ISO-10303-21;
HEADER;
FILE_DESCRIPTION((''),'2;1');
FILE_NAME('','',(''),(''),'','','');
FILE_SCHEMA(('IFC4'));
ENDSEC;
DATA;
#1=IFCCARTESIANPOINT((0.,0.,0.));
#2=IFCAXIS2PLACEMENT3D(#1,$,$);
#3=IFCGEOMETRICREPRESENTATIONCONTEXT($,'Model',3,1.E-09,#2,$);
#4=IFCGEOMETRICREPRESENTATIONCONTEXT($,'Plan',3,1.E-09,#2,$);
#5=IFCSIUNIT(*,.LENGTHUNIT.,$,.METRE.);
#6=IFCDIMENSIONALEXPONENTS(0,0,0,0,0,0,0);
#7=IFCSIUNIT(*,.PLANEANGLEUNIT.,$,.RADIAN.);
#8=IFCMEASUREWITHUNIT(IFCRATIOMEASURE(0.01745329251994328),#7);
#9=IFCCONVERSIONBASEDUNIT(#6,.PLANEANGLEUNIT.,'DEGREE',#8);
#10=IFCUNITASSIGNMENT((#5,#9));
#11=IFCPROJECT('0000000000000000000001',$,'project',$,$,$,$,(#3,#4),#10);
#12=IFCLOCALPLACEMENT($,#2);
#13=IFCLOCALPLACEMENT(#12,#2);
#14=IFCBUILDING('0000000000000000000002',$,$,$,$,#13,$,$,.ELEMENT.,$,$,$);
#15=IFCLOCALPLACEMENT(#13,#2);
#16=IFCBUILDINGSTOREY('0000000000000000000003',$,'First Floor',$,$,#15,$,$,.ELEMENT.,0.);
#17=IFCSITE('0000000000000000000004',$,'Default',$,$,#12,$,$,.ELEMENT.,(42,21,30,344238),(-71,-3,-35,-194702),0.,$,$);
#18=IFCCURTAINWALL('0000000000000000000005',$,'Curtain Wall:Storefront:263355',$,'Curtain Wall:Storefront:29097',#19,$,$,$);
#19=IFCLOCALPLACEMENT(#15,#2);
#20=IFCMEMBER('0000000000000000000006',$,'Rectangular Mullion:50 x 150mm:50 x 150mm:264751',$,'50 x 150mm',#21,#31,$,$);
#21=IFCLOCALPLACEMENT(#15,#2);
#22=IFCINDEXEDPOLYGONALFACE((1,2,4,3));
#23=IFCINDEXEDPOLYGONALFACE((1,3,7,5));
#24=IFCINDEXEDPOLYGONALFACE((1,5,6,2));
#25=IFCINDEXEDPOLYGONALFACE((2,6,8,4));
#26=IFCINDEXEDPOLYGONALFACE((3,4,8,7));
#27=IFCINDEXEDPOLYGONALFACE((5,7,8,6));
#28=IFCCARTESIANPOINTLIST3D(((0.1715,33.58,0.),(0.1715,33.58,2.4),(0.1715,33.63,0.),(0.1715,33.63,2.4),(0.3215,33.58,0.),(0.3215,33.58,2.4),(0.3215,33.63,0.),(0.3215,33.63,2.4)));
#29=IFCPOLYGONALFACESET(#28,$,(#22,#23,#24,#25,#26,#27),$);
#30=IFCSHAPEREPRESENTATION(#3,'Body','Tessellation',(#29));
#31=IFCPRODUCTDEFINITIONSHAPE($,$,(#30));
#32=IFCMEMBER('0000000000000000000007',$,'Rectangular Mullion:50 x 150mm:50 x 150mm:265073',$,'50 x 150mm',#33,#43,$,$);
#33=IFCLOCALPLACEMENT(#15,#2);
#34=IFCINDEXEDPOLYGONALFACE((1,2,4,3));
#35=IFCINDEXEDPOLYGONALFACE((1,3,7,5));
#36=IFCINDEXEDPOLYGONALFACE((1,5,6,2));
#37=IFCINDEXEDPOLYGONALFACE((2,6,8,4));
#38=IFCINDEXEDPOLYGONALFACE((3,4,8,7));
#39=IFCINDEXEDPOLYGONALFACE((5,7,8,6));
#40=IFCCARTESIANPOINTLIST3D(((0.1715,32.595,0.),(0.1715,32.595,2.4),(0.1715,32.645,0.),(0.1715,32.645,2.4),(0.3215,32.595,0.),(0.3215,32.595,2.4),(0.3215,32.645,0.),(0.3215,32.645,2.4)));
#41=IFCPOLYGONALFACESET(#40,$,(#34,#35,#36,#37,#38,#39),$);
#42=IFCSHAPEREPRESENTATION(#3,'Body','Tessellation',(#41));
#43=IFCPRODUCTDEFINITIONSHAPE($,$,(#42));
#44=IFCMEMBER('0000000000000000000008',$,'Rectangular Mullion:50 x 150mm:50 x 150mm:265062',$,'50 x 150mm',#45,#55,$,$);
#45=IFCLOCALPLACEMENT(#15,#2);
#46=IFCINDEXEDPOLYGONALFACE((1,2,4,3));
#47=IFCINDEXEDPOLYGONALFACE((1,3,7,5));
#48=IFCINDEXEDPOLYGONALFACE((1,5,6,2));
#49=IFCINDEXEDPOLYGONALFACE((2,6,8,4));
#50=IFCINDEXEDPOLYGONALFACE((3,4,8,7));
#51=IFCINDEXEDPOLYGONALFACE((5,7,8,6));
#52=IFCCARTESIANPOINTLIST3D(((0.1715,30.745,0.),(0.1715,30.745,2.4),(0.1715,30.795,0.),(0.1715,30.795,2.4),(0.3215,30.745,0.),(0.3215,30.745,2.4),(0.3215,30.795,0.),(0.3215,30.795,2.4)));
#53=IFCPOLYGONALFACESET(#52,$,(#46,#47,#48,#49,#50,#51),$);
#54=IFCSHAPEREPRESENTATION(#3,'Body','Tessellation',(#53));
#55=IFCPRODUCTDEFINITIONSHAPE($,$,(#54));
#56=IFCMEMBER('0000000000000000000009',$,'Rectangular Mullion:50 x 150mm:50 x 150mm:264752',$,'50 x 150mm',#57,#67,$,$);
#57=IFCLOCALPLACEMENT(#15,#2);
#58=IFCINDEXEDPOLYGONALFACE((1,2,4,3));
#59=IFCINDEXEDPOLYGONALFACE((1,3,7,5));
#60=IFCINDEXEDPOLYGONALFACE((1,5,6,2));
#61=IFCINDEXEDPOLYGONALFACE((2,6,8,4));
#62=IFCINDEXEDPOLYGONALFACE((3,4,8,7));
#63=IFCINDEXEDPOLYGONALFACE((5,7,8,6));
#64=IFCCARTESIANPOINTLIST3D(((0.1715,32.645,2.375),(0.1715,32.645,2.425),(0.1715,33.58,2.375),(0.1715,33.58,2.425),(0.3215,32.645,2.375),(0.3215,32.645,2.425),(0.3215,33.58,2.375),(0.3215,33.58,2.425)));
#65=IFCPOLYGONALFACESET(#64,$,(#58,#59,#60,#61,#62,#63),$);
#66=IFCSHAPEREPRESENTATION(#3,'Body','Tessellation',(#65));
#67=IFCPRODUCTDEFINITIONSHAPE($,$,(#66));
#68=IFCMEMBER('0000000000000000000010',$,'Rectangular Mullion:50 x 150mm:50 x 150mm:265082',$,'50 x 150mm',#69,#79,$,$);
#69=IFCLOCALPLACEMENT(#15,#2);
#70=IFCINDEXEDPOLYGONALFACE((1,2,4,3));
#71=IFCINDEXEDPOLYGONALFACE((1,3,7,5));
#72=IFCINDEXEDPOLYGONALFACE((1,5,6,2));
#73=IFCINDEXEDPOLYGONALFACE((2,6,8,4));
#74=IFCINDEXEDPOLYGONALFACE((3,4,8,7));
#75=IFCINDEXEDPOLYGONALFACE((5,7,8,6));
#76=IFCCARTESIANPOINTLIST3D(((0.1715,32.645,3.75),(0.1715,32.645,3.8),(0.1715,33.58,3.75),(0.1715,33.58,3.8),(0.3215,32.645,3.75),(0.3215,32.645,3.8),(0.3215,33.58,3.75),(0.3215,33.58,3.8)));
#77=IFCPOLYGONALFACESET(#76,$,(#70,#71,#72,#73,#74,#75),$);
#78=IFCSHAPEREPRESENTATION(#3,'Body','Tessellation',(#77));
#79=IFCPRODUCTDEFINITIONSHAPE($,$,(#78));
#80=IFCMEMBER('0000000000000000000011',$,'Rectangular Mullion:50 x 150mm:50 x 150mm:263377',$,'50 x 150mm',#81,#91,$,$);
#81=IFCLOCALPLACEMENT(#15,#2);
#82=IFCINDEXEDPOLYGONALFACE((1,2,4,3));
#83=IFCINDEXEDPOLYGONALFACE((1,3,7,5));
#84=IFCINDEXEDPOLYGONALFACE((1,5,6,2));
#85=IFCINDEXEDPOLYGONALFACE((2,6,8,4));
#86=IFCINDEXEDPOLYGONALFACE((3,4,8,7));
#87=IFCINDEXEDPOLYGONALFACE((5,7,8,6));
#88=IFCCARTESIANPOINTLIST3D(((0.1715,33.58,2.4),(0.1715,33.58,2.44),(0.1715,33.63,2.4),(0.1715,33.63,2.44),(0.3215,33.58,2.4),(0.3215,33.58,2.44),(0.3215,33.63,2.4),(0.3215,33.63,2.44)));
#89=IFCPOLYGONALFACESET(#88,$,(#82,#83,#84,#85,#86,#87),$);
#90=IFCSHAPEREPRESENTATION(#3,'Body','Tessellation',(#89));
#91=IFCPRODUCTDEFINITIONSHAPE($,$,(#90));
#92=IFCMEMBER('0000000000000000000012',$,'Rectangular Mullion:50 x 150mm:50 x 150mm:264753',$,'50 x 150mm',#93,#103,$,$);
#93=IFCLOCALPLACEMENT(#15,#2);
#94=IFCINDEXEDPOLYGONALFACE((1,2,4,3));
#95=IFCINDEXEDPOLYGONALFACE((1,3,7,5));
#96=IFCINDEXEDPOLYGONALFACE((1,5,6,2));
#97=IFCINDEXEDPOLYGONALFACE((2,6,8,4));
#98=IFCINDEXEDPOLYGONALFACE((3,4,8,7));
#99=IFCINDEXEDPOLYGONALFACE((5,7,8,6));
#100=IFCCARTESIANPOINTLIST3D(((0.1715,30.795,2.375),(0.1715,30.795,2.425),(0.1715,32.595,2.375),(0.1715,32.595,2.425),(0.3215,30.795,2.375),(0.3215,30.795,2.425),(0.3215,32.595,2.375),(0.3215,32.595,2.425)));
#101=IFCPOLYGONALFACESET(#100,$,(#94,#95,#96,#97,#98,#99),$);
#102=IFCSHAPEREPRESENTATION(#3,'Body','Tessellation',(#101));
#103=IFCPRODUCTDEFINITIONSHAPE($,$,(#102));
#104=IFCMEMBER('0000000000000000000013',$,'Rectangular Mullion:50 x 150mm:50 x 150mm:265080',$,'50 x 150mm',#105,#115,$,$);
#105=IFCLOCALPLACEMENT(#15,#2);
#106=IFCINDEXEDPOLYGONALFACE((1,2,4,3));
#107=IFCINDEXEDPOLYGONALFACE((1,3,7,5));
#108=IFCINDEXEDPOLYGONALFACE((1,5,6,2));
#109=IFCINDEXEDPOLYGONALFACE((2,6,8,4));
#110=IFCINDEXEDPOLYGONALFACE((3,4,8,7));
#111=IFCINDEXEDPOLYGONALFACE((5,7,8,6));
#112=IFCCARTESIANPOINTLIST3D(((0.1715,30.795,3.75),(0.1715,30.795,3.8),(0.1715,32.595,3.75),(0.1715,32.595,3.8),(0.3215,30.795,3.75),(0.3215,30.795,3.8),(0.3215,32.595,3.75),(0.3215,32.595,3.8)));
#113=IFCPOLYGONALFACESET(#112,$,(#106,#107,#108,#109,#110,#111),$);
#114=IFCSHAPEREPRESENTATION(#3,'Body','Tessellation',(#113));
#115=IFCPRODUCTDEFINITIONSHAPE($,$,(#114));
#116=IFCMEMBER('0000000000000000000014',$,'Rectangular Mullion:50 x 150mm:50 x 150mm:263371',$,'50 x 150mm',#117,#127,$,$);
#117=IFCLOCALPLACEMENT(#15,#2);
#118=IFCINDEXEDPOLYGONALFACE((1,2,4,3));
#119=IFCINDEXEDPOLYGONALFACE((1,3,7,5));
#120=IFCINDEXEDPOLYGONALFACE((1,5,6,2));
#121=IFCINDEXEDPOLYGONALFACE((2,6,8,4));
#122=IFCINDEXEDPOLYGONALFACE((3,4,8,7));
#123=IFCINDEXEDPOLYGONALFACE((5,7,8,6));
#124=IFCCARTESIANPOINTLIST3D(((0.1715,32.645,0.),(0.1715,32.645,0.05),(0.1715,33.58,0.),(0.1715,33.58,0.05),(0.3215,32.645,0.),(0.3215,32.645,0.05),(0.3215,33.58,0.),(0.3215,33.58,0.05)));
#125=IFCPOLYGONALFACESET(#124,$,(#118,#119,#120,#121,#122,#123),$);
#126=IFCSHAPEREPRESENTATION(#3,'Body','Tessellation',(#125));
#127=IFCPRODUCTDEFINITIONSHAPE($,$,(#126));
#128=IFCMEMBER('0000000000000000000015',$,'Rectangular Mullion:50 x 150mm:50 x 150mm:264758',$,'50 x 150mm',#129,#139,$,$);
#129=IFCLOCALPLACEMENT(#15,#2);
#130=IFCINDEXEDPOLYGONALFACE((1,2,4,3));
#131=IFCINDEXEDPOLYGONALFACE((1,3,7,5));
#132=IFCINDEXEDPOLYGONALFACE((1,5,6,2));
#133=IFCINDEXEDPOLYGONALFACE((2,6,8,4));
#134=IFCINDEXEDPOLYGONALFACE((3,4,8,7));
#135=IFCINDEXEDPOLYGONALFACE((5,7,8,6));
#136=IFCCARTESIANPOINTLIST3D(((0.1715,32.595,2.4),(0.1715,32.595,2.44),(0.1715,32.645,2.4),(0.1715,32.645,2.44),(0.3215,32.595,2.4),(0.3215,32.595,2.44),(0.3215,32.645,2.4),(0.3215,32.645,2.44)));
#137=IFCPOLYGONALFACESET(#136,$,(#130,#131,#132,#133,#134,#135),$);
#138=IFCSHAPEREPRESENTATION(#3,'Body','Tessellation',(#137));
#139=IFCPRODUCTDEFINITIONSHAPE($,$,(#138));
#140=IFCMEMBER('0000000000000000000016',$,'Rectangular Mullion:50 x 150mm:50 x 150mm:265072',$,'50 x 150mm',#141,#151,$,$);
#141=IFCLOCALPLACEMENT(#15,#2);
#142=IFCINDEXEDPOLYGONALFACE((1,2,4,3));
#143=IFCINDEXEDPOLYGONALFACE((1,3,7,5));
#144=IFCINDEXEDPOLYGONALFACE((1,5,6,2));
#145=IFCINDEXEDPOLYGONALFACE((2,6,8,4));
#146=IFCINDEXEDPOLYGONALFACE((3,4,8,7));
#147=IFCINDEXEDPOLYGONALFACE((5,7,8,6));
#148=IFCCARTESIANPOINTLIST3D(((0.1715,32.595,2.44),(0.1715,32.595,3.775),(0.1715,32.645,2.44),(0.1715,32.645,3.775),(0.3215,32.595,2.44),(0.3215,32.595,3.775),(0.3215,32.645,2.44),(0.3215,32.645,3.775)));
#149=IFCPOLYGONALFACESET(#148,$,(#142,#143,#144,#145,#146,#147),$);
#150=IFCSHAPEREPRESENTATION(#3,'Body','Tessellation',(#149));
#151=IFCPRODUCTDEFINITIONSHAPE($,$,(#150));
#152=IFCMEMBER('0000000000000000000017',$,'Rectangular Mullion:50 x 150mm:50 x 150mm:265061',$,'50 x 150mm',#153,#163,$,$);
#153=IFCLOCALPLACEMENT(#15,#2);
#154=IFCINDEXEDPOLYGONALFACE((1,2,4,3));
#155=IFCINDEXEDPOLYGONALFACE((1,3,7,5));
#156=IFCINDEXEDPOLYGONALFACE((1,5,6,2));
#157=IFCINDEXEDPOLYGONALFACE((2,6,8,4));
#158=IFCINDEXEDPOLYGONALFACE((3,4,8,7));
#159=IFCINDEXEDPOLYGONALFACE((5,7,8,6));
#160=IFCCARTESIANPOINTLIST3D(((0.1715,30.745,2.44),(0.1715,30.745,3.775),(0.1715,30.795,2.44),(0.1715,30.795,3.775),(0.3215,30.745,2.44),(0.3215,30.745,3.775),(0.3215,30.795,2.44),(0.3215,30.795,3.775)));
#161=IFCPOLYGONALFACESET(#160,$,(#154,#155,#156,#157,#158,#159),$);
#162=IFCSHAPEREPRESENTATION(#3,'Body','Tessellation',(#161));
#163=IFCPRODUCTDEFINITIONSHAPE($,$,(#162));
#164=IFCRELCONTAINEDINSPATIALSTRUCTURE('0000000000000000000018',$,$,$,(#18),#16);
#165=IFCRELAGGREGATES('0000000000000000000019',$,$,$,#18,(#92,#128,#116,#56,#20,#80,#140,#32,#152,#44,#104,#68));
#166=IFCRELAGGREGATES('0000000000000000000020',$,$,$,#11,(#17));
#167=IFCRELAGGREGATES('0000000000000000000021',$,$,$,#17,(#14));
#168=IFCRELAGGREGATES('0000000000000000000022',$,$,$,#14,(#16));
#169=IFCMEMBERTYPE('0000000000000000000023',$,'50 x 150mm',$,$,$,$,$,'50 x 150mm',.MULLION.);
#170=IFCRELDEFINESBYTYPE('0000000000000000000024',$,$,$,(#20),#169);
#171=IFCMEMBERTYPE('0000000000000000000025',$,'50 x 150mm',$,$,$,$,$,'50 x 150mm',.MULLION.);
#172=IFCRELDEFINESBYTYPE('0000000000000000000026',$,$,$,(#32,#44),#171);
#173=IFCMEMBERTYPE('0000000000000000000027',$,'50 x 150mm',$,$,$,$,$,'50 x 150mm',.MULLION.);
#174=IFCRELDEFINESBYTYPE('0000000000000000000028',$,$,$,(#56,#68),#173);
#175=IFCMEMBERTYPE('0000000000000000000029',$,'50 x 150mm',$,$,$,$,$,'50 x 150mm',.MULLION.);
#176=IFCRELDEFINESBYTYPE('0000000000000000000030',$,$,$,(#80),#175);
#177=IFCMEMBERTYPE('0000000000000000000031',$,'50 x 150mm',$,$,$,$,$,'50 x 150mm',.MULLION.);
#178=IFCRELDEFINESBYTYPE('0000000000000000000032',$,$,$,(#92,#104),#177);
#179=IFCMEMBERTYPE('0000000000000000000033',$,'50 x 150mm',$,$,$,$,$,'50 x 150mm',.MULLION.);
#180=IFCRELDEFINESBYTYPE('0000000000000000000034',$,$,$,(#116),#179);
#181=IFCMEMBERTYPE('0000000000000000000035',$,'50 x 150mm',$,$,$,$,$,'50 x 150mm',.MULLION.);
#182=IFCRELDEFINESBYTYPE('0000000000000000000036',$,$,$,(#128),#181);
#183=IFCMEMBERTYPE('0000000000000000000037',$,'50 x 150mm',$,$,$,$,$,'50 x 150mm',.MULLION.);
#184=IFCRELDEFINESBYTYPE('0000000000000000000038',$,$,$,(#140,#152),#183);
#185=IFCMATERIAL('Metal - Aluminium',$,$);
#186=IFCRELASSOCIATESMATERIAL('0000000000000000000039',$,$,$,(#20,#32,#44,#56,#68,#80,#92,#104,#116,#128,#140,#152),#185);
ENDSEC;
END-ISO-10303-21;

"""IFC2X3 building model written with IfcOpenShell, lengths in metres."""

from ifc_helpers import new_model, entity, si_unit, converted_unit, frame, origin, origin_2d_with_axis, place, context, project, spatial, rectangle, extrude, source, transform, mapped, material, type_object, type_shapes, element, aggregate, save


model = new_model("IFC2X3")

# Units and contexts
model_context = context("Model", 3, precision=1e-09, world=origin())
plan_context = context("Plan", 3, precision=1e-09, world=origin())
ifc_project = project(units=[si_unit("LENGTHUNIT", "METRE"), converted_unit("PLANEANGLEUNIT", "DEGREE", entity("IfcRatioMeasure", 0.01745329251994328), si_unit("PLANEANGLEUNIT", "RADIAN"), dimensions=[0, 0, 0, 0, 0, 0, 0])], contexts=[model_context, plan_context])

# Site, building, storey
site_placement = place(None, origin())
site = spatial("IfcSite", under=ifc_project, at=site_placement, Name="Default", CompositionType="ELEMENT", RefLatitude=(42, 21, 30, 344238), RefLongitude=(-71, -3, -35, -194702), RefElevation=0.0)
building_placement = place(site_placement, origin())
building = spatial("IfcBuilding", under=site, at=building_placement, CompositionType="ELEMENT")
storey_placement = place(building_placement, origin())
storey = spatial("IfcBuildingStorey", under=building, at=storey_placement, Name="First Floor", CompositionType="ELEMENT", Elevation=0.0)

# Curtain wall, members
curtain_wall_placement = place(storey_placement, origin())
curtain_wall = element("IfcCurtainWall", 1, at=curtain_wall_placement, inside=storey, Name="Curtain Wall:Storefront:263355", ObjectType="Curtain Wall:Storefront:29097")
ifc_material_1 = material(Name="Metal - Aluminium")
member_type_1 = type_object("IfcMemberType", Name="50 x 150mm", ElementType="50 x 150mm", PredefinedType="MULLION")
shared_shape_1 = source(origin(), model_context, "Body", "SweptSolid", [
    extrude(rectangle(XDim=0.05, YDim=0.15, at=origin_2d_with_axis()), frame((-0.025, 0.0, -2.4), z_axis=(0.0, 0.0, 1.0), x_axis=(-1.0, 0.0, 0.0)), (0.0, 0.0, 1.0), 2.4),
])
type_shapes(member_type_1, [shared_shape_1])
member_1_placement = place(storey_placement, frame((0.2465, 33.63, 2.4), z_axis=(0.0, 0.0, 1.0), x_axis=(0.0, 1.0, 0.0)))
member_1 = element("IfcMember", 2, at=member_1_placement, type_object=member_type_1, material=ifc_material_1, Name="Rectangular Mullion:50 x 150mm:50 x 150mm:264751", ObjectType="50 x 150mm", context=model_context, shape_type="MappedRepresentation", body=[
    mapped(shared_shape_1, transform((0.0, 0.0, 0.0), scale=1.0)),
])
member_type_2 = type_object("IfcMemberType", Name="50 x 150mm", ElementType="50 x 150mm", PredefinedType="MULLION")
shared_shape_2 = source(origin(), model_context, "Body", "SweptSolid", [
    extrude(rectangle(XDim=0.05, YDim=0.15, at=origin_2d_with_axis()), frame((0.0, 0.0, -2.4), z_axis=(0.0, 0.0, 1.0), x_axis=(-1.0, 0.0, 0.0)), (0.0, 0.0, 1.0), 2.4),
])
type_shapes(member_type_2, [shared_shape_2])
member_2_placement = place(storey_placement, frame((0.2465, 32.62, 0.0), z_axis=(0.0, 0.0, -1.0), x_axis=(0.0, -1.0, 0.0)))
member_2 = element("IfcMember", 3, at=member_2_placement, type_object=member_type_2, material=ifc_material_1, Name="Rectangular Mullion:50 x 150mm:50 x 150mm:265073", ObjectType="50 x 150mm", context=model_context, shape_type="MappedRepresentation", body=[
    mapped(shared_shape_2, transform((0.0, 0.0, 0.0), scale=1.0)),
])
member_3_placement = place(storey_placement, frame((0.2465, 30.77, 0.0), z_axis=(0.0, 0.0, -1.0), x_axis=(0.0, -1.0, 0.0)))
member_3 = element("IfcMember", 4, at=member_3_placement, type_object=member_type_2, material=ifc_material_1, Name="Rectangular Mullion:50 x 150mm:50 x 150mm:265062", ObjectType="50 x 150mm", context=model_context, shape_type="MappedRepresentation", body=[
    mapped(shared_shape_2, transform((0.0, 0.0, 0.0), scale=1.0)),
])
member_type_3 = type_object("IfcMemberType", Name="50 x 150mm", ElementType="50 x 150mm", PredefinedType="MULLION")
shared_shape_3 = source(origin(), model_context, "Body", "SweptSolid", [
    extrude(rectangle(XDim=0.05, YDim=0.15, at=origin_2d_with_axis()), frame((0.0, 0.0, -0.935), z_axis=(0.0, 0.0, 1.0), x_axis=(-1.0, 0.0, 0.0)), (0.0, 0.0, 1.0), 0.935),
])
type_shapes(member_type_3, [shared_shape_3])
member_4_placement = place(storey_placement, frame((0.2465, 32.645, 2.4), z_axis=(0.0, -1.0, 0.0), x_axis=(0.0, 0.0, 1.0)))
member_4 = element("IfcMember", 5, at=member_4_placement, type_object=member_type_3, material=ifc_material_1, Name="Rectangular Mullion:50 x 150mm:50 x 150mm:264752", ObjectType="50 x 150mm", context=model_context, shape_type="MappedRepresentation", body=[
    mapped(shared_shape_3, transform((0.0, 0.0, 0.0), scale=1.0)),
])
member_5_placement = place(storey_placement, frame((0.2465, 32.645, 3.775), z_axis=(0.0, -1.0, 0.0), x_axis=(0.0, 0.0, 1.0)))
member_5 = element("IfcMember", 6, at=member_5_placement, type_object=member_type_3, material=ifc_material_1, Name="Rectangular Mullion:50 x 150mm:50 x 150mm:265082", ObjectType="50 x 150mm", context=model_context, shape_type="MappedRepresentation", body=[
    mapped(shared_shape_3, transform((0.0, 0.0, 0.0), scale=1.0)),
])
member_type_4 = type_object("IfcMemberType", Name="50 x 150mm", ElementType="50 x 150mm", PredefinedType="MULLION")
shared_shape_4 = source(origin(), model_context, "Body", "SweptSolid", [
    extrude(rectangle(XDim=0.05, YDim=0.15, at=origin_2d_with_axis()), frame((-0.025, 0.0, -0.04), z_axis=(0.0, 0.0, 1.0), x_axis=(-1.0, 0.0, 0.0)), (0.0, 0.0, 1.0), 0.04),
])
type_shapes(member_type_4, [shared_shape_4])
member_6_placement = place(storey_placement, frame((0.2465, 33.63, 2.44), z_axis=(0.0, 0.0, 1.0), x_axis=(0.0, 1.0, 0.0)))
member_6 = element("IfcMember", 7, at=member_6_placement, type_object=member_type_4, material=ifc_material_1, Name="Rectangular Mullion:50 x 150mm:50 x 150mm:263377", ObjectType="50 x 150mm", context=model_context, shape_type="MappedRepresentation", body=[
    mapped(shared_shape_4, transform((0.0, 0.0, 0.0), scale=1.0)),
])
member_type_5 = type_object("IfcMemberType", Name="50 x 150mm", ElementType="50 x 150mm", PredefinedType="MULLION")
shared_shape_5 = source(origin(), model_context, "Body", "SweptSolid", [
    extrude(rectangle(XDim=0.05, YDim=0.15, at=origin_2d_with_axis()), frame((0.0, 0.0, -1.8), z_axis=(0.0, 0.0, 1.0), x_axis=(-1.0, 0.0, 0.0)), (0.0, 0.0, 1.0), 1.8),
])
type_shapes(member_type_5, [shared_shape_5])
member_7_placement = place(storey_placement, frame((0.2465, 30.795, 2.4), z_axis=(0.0, -1.0, 0.0), x_axis=(0.0, 0.0, 1.0)))
member_7 = element("IfcMember", 8, at=member_7_placement, type_object=member_type_5, material=ifc_material_1, Name="Rectangular Mullion:50 x 150mm:50 x 150mm:264753", ObjectType="50 x 150mm", context=model_context, shape_type="MappedRepresentation", body=[
    mapped(shared_shape_5, transform((0.0, 0.0, 0.0), scale=1.0)),
])
member_8_placement = place(storey_placement, frame((0.2465, 30.795, 3.775), z_axis=(0.0, -1.0, 0.0), x_axis=(0.0, 0.0, 1.0)))
member_8 = element("IfcMember", 9, at=member_8_placement, type_object=member_type_5, material=ifc_material_1, Name="Rectangular Mullion:50 x 150mm:50 x 150mm:265080", ObjectType="50 x 150mm", context=model_context, shape_type="MappedRepresentation", body=[
    mapped(shared_shape_5, transform((0.0, 0.0, 0.0), scale=1.0)),
])
member_type_6 = type_object("IfcMemberType", Name="50 x 150mm", ElementType="50 x 150mm", PredefinedType="MULLION")
shared_shape_6 = source(origin(), model_context, "Body", "SweptSolid", [
    extrude(rectangle(XDim=0.05, YDim=0.15, at=origin_2d_with_axis()), frame((-0.025, 0.0, -0.935), z_axis=(0.0, 0.0, 1.0), x_axis=(-1.0, 0.0, 0.0)), (0.0, 0.0, 1.0), 0.935),
])
type_shapes(member_type_6, [shared_shape_6])
member_9_placement = place(storey_placement, frame((0.2465, 33.58, 0.0), z_axis=(0.0, 1.0, 0.0), x_axis=(0.0, 0.0, -1.0)))
member_9 = element("IfcMember", 10, at=member_9_placement, type_object=member_type_6, material=ifc_material_1, Name="Rectangular Mullion:50 x 150mm:50 x 150mm:263371", ObjectType="50 x 150mm", context=model_context, shape_type="MappedRepresentation", body=[
    mapped(shared_shape_6, transform((0.0, 0.0, 0.0), scale=1.0)),
])
member_type_7 = type_object("IfcMemberType", Name="50 x 150mm", ElementType="50 x 150mm", PredefinedType="MULLION")
shared_shape_7 = source(origin(), model_context, "Body", "SweptSolid", [
    extrude(rectangle(XDim=0.05, YDim=0.15, at=origin_2d_with_axis()), frame((0.0, 0.0, -0.04), z_axis=(0.0, 0.0, 1.0), x_axis=(-1.0, 0.0, 0.0)), (0.0, 0.0, 1.0), 0.04),
])
type_shapes(member_type_7, [shared_shape_7])
member_10_placement = place(storey_placement, frame((0.2465, 32.62, 2.4), z_axis=(0.0, 0.0, -1.0), x_axis=(0.0, -1.0, 0.0)))
member_10 = element("IfcMember", 11, at=member_10_placement, type_object=member_type_7, material=ifc_material_1, Name="Rectangular Mullion:50 x 150mm:50 x 150mm:264758", ObjectType="50 x 150mm", context=model_context, shape_type="MappedRepresentation", body=[
    mapped(shared_shape_7, transform((0.0, 0.0, 0.0), scale=1.0)),
])
member_type_8 = type_object("IfcMemberType", Name="50 x 150mm", ElementType="50 x 150mm", PredefinedType="MULLION")
shared_shape_8 = source(origin(), model_context, "Body", "SweptSolid", [
    extrude(rectangle(XDim=0.05, YDim=0.15, at=origin_2d_with_axis()), frame((0.0, 0.0, -1.335), z_axis=(0.0, 0.0, 1.0), x_axis=(-1.0, 0.0, 0.0)), (0.0, 0.0, 1.0), 1.335),
])
type_shapes(member_type_8, [shared_shape_8])
member_11_placement = place(storey_placement, frame((0.2465, 32.62, 2.44), z_axis=(0.0, 0.0, -1.0), x_axis=(0.0, -1.0, 0.0)))
member_11 = element("IfcMember", 12, at=member_11_placement, type_object=member_type_8, material=ifc_material_1, Name="Rectangular Mullion:50 x 150mm:50 x 150mm:265072", ObjectType="50 x 150mm", context=model_context, shape_type="MappedRepresentation", body=[
    mapped(shared_shape_8, transform((0.0, 0.0, 0.0), scale=1.0)),
])
member_12_placement = place(storey_placement, frame((0.2465, 30.77, 2.44), z_axis=(0.0, 0.0, -1.0), x_axis=(0.0, -1.0, 0.0)))
member_12 = element("IfcMember", 13, at=member_12_placement, type_object=member_type_8, material=ifc_material_1, Name="Rectangular Mullion:50 x 150mm:50 x 150mm:265061", ObjectType="50 x 150mm", context=model_context, shape_type="MappedRepresentation", body=[
    mapped(shared_shape_8, transform((0.0, 0.0, 0.0), scale=1.0)),
])
aggregate(curtain_wall, [member_7, member_10, member_9, member_4, member_1, member_6, member_11, member_2, member_12, member_3, member_8, member_5])

save(model, "model.ifc")
